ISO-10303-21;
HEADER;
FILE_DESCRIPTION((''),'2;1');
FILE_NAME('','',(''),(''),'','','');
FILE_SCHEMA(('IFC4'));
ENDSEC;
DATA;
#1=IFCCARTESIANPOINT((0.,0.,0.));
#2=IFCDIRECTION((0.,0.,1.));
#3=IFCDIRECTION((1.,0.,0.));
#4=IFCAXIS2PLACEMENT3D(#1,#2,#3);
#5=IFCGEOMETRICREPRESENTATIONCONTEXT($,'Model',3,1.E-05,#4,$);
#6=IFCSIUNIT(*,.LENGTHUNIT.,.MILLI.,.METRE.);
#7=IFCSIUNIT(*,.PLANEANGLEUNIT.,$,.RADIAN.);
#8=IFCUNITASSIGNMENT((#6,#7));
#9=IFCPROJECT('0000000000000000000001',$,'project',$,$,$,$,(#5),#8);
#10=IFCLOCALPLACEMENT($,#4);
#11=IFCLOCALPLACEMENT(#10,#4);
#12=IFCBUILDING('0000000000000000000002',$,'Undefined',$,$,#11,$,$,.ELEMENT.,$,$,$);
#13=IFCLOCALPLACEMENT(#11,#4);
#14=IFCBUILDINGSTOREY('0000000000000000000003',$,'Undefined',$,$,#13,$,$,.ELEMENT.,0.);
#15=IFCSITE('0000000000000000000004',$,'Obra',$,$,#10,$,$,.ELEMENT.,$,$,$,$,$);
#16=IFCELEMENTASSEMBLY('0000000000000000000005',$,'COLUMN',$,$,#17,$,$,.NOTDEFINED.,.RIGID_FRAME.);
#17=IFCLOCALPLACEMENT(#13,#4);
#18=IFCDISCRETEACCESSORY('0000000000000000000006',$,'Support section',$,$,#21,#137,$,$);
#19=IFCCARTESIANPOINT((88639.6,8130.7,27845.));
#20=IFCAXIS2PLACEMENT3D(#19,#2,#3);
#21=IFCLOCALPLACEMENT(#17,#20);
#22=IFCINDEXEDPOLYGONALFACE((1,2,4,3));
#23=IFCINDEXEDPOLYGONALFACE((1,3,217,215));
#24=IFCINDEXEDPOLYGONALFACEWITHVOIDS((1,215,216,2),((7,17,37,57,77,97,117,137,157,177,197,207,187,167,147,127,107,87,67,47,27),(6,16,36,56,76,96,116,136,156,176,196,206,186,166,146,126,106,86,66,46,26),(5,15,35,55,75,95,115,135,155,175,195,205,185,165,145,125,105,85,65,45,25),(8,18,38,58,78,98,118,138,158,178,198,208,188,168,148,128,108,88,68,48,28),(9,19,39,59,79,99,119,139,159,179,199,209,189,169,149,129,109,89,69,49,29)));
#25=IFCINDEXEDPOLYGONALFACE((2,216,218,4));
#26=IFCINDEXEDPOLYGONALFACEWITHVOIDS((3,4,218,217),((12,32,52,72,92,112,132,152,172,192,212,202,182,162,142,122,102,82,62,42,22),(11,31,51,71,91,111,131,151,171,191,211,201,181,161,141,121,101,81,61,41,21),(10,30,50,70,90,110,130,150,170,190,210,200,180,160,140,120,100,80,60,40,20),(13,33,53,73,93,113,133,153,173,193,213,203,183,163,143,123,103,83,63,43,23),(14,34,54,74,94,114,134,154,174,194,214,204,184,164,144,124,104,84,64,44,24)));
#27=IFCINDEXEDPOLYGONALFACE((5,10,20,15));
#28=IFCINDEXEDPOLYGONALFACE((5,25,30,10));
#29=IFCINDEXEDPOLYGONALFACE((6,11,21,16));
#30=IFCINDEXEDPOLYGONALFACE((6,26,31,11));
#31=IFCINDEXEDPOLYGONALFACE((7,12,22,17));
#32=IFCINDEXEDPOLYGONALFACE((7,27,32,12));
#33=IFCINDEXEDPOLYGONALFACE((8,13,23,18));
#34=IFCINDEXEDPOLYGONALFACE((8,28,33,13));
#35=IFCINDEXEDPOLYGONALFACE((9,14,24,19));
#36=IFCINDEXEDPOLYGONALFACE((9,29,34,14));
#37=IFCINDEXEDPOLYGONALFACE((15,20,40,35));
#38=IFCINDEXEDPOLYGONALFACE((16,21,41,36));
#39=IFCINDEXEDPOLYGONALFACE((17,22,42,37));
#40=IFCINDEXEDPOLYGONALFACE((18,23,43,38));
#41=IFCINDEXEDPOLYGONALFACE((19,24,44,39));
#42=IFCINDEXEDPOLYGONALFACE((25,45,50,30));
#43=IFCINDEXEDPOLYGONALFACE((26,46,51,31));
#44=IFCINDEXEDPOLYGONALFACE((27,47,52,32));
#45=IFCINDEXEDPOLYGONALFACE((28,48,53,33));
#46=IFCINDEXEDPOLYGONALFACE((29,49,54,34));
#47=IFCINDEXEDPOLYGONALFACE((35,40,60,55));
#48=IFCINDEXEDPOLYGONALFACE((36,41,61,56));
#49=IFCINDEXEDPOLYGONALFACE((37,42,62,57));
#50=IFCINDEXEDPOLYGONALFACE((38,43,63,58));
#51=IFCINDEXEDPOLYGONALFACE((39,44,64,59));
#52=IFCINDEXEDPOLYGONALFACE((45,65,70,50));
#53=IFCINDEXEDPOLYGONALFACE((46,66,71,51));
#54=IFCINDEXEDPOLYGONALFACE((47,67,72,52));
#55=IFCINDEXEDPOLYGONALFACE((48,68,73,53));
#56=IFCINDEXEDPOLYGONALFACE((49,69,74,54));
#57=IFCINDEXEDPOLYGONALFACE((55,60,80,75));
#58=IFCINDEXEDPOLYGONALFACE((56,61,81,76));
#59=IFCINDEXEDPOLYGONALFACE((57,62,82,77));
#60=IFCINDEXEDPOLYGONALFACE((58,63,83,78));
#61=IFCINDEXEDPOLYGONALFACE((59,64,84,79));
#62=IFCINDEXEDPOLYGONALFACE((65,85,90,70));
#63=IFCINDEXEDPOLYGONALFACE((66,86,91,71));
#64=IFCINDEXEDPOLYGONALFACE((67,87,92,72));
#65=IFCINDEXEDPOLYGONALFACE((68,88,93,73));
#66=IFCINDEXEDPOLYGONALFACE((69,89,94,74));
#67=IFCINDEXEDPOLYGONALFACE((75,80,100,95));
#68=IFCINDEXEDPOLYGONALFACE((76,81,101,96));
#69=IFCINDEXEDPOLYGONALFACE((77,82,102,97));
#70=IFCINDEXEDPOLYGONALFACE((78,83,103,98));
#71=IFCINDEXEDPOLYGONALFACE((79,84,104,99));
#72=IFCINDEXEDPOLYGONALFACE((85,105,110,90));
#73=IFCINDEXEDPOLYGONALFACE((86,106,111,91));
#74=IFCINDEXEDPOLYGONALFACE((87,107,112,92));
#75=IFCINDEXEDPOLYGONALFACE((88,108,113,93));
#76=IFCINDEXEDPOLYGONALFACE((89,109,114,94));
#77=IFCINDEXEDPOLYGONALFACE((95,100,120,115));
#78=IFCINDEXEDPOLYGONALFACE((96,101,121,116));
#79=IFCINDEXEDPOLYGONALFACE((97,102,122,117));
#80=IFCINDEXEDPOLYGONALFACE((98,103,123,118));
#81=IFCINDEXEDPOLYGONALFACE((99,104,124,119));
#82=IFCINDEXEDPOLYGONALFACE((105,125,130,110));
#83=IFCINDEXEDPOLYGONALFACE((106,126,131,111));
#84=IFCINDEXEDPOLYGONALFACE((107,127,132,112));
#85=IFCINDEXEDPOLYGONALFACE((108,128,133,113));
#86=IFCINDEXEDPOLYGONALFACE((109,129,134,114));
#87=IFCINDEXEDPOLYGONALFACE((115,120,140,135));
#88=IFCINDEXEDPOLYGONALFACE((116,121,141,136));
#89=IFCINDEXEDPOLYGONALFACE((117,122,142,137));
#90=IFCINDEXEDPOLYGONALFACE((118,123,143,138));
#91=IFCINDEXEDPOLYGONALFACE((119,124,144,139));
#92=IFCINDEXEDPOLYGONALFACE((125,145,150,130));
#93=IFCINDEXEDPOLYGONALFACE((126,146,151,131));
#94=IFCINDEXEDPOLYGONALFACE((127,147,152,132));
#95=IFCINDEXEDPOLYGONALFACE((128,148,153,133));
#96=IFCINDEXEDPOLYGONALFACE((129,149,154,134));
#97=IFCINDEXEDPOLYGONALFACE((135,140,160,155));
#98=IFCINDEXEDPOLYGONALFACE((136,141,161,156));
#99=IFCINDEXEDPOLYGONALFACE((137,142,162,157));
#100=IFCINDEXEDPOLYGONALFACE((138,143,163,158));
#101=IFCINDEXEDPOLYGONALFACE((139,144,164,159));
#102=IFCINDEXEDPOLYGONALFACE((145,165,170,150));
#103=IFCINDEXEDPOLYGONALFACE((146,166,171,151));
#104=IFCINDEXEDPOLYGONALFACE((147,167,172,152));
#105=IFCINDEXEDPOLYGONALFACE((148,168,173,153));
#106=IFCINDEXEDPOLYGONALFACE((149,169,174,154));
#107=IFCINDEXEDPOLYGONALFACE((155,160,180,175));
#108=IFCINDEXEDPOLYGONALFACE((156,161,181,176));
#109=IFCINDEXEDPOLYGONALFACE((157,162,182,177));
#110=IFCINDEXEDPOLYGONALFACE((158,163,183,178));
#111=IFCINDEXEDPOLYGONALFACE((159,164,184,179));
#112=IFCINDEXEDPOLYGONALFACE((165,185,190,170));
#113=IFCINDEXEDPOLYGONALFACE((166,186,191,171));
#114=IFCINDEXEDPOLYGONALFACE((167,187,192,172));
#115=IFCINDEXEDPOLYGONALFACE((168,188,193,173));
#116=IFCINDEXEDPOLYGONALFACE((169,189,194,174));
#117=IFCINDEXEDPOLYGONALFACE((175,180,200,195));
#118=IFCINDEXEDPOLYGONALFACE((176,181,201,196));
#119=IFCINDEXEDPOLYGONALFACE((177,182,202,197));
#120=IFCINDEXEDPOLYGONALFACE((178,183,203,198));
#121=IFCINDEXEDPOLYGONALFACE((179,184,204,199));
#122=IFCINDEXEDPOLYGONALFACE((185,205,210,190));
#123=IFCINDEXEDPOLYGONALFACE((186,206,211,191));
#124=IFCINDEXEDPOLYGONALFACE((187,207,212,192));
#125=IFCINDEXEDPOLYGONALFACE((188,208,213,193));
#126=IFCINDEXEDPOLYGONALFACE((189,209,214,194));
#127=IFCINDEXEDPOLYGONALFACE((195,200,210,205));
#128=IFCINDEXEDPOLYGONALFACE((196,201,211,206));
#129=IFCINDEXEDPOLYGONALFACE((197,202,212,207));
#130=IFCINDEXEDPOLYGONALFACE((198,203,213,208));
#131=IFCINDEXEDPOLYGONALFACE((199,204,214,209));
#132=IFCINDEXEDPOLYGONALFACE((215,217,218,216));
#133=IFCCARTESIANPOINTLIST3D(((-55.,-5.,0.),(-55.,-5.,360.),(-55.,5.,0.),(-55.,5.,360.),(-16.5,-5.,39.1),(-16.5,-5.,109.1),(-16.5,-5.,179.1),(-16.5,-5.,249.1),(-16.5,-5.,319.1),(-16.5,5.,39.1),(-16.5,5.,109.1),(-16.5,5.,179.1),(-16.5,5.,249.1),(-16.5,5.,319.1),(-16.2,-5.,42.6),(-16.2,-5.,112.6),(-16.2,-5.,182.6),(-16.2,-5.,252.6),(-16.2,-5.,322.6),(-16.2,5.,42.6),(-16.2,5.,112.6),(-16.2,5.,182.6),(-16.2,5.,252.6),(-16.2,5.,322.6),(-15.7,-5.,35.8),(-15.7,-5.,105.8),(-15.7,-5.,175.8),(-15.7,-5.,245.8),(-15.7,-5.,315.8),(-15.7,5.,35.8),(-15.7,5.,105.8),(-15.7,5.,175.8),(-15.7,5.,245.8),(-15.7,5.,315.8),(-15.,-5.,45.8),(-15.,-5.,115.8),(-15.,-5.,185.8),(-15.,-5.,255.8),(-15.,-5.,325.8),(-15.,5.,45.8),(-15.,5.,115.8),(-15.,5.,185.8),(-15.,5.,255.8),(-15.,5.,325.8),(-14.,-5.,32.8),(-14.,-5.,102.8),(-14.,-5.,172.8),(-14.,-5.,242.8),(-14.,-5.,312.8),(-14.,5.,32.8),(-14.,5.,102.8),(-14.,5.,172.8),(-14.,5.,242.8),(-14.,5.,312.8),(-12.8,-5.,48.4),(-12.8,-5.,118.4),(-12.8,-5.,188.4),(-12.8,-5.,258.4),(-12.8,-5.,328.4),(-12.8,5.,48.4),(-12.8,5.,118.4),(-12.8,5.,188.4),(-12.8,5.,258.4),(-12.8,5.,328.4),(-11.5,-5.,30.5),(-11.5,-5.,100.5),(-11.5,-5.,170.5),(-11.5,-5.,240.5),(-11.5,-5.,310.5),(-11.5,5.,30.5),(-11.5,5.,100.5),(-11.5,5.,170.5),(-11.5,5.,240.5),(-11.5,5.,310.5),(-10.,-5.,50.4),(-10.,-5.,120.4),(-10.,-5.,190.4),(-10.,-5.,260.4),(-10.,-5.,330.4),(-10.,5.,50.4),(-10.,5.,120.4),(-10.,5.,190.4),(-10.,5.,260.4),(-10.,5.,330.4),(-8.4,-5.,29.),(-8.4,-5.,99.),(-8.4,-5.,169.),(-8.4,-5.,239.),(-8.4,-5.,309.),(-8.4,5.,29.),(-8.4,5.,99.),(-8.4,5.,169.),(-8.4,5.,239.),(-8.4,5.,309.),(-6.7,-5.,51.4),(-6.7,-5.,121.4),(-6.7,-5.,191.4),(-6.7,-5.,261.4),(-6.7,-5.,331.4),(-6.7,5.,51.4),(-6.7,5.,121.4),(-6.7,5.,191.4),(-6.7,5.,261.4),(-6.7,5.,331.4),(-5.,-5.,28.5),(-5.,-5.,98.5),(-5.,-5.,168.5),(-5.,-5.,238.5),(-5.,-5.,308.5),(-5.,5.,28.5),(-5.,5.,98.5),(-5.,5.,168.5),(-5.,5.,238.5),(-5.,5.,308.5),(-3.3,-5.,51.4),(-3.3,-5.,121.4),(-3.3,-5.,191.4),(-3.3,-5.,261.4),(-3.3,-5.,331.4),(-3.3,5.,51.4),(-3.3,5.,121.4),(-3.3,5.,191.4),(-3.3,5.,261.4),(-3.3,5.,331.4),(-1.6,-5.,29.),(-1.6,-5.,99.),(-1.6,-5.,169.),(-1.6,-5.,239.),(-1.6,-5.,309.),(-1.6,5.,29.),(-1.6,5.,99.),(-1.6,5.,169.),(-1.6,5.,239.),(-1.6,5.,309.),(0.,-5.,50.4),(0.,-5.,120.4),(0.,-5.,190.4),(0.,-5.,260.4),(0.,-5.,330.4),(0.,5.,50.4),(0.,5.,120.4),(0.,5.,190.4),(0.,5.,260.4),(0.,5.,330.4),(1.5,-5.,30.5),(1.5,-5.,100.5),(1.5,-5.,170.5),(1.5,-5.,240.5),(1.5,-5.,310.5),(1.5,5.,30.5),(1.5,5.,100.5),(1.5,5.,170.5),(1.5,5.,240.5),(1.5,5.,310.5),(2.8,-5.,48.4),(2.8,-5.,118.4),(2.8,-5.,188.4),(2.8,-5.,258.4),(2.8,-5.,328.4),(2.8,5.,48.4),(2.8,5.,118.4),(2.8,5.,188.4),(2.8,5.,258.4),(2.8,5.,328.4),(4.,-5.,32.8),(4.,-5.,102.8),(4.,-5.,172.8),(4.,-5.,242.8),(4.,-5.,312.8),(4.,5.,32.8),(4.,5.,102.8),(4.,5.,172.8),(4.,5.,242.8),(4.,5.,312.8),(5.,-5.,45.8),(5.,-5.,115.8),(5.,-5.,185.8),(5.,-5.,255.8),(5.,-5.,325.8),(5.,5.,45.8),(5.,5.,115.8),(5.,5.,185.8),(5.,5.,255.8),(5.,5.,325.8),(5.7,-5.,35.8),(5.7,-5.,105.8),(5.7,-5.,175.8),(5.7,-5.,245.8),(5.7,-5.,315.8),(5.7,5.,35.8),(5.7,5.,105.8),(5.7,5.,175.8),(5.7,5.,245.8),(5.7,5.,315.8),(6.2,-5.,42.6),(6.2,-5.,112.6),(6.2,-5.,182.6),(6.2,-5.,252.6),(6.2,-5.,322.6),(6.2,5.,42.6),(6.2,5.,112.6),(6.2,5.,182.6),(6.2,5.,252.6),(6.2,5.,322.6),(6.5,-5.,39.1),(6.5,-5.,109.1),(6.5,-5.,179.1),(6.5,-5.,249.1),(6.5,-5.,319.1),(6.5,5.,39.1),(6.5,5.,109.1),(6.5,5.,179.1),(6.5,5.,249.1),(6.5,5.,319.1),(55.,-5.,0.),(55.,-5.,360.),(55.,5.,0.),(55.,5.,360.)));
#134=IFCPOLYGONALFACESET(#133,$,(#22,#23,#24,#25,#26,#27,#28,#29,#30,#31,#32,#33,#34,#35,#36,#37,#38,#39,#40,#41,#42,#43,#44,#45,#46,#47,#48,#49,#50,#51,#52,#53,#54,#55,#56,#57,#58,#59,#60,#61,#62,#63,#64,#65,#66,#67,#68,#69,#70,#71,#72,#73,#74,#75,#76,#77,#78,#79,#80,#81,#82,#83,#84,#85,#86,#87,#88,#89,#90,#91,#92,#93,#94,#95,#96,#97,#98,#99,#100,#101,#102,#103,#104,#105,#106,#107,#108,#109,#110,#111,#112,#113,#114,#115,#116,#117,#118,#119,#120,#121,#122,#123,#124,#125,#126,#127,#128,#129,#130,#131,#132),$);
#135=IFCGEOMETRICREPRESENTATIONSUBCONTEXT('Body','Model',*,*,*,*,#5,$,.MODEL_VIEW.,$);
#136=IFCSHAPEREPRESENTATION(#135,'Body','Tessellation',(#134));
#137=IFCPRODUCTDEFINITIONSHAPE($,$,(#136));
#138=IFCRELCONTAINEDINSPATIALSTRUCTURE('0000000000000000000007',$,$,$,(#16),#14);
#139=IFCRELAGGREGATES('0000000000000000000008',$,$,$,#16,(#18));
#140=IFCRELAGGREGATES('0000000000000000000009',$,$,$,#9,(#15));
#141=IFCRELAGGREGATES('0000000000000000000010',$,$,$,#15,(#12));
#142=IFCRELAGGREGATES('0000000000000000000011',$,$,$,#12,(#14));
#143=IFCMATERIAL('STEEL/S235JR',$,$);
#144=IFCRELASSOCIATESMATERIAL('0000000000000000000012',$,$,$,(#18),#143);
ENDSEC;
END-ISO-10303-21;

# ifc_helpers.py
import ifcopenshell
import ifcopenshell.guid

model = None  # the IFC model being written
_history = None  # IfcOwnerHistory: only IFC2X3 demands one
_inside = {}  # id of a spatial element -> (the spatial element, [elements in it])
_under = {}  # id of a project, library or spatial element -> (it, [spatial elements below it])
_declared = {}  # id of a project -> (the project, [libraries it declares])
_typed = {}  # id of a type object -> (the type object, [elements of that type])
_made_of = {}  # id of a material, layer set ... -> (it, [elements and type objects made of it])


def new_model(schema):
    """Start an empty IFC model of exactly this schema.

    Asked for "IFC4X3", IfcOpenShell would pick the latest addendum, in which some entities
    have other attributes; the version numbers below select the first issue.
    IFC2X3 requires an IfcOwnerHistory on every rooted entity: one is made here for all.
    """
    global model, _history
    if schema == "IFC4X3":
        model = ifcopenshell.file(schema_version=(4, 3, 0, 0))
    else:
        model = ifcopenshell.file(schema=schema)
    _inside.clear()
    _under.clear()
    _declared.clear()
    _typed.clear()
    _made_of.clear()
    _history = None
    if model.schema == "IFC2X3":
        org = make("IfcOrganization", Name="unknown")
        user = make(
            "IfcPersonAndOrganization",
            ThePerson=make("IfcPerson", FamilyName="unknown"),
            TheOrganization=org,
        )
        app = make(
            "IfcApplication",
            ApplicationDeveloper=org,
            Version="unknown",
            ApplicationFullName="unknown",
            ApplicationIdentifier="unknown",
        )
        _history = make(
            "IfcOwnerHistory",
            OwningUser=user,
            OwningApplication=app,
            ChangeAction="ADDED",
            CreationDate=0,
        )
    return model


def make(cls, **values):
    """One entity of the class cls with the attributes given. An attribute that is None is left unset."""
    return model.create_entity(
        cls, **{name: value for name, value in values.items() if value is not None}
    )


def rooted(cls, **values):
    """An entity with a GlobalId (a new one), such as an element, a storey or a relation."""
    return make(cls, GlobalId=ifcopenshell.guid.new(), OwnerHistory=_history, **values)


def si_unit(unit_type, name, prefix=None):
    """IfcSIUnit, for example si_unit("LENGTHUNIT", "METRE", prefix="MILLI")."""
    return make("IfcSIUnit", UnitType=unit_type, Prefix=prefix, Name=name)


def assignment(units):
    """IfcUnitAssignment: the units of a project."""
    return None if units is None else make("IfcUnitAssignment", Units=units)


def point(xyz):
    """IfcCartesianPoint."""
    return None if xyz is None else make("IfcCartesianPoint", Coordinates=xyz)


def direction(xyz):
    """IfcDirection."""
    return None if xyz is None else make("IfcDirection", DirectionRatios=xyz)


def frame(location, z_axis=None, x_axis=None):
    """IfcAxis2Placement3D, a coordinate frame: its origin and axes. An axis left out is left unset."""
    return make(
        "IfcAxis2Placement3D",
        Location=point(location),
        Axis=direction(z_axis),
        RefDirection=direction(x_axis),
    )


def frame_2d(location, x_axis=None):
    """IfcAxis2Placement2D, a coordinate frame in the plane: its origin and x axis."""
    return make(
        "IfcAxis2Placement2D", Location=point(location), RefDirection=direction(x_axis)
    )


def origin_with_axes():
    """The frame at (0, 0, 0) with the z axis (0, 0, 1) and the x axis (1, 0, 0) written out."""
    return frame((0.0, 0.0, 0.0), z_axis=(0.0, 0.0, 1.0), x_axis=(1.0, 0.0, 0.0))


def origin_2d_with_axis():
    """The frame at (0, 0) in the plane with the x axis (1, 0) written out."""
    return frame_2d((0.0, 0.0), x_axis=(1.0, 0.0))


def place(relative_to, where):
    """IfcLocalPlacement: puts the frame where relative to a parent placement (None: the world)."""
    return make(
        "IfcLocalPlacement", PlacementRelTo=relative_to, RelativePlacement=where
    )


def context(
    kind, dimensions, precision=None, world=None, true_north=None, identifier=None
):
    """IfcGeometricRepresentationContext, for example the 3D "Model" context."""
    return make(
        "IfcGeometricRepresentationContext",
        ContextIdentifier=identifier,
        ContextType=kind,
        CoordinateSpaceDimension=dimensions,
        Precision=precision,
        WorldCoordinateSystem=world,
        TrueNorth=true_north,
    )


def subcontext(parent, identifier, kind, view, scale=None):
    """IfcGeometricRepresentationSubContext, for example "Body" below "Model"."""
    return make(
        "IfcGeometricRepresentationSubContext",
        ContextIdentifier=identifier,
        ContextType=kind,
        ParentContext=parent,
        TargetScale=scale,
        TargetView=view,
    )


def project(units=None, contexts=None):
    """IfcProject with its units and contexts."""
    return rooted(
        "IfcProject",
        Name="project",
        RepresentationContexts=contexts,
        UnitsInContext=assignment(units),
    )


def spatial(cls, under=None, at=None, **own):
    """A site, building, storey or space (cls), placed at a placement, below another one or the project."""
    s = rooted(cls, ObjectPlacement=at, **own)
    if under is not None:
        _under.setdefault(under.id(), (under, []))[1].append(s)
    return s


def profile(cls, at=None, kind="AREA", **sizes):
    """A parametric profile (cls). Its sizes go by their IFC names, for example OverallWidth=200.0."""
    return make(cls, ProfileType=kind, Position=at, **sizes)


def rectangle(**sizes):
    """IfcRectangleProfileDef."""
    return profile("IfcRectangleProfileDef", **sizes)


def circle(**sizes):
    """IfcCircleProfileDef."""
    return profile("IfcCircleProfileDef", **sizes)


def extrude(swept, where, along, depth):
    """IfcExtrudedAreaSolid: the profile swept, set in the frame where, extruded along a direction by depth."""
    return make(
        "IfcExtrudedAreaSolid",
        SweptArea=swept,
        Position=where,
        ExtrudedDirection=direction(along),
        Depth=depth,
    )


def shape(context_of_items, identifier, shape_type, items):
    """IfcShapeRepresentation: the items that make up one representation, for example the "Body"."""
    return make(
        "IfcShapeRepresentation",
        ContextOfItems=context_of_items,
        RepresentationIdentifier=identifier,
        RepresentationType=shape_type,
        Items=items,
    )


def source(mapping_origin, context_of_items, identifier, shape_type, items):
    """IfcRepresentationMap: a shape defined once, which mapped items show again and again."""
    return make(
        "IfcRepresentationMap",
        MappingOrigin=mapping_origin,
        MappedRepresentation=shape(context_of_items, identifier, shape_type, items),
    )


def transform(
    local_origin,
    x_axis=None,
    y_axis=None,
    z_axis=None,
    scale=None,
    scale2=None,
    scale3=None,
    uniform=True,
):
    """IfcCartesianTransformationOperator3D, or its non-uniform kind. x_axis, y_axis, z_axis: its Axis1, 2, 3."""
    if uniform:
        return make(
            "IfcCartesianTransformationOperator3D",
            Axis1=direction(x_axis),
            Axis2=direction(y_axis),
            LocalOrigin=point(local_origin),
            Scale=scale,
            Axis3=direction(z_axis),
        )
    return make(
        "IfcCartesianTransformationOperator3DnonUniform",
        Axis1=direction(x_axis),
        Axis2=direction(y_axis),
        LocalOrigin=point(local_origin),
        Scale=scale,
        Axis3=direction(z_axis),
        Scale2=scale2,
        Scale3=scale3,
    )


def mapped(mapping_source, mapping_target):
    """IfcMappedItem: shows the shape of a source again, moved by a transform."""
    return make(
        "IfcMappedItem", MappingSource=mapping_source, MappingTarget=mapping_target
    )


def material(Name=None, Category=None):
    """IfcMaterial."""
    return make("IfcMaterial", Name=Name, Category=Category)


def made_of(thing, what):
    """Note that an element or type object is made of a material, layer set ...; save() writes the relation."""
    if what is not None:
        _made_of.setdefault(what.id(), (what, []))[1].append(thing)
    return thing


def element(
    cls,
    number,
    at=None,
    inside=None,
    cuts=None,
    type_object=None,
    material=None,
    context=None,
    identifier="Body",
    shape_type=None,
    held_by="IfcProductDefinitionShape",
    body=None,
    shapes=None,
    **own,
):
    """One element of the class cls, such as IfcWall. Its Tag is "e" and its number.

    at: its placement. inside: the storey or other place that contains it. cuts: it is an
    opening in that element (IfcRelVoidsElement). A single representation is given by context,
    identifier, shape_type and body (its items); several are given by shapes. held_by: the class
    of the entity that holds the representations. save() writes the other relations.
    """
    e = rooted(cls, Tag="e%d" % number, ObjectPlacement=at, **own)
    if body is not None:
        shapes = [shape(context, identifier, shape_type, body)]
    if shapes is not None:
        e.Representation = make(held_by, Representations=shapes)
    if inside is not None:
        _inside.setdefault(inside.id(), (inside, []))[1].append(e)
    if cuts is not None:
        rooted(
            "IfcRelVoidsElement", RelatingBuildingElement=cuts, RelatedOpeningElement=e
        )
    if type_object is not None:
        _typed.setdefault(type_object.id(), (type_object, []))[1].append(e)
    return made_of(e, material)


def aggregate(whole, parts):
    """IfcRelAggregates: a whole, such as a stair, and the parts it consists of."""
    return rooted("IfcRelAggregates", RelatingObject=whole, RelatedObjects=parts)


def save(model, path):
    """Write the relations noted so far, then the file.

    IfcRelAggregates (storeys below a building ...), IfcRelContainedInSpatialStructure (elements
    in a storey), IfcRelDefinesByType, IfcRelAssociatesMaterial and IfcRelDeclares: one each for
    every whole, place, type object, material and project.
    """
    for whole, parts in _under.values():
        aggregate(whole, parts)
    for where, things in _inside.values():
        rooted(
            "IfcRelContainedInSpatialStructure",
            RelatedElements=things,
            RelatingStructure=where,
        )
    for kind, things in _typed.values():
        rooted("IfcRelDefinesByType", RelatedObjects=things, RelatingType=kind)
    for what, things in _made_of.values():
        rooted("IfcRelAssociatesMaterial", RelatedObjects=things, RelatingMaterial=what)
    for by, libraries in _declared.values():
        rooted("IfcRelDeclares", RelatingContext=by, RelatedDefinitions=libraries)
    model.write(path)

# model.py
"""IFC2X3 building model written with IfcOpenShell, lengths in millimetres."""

from ifc_helpers import new_model, si_unit, frame, origin_with_axes, origin_2d_with_axis, place, context, subcontext, project, spatial, rectangle, circle, extrude, source, transform, mapped, material, element, aggregate, save


model = new_model("IFC2X3")

# Units and contexts
model_context = context("Model", 3, precision=1e-05, world=origin_with_axes())
body_context = subcontext(model_context, "Body", "Model", "MODEL_VIEW")
ifc_project = project(units=[si_unit("LENGTHUNIT", "METRE", prefix="MILLI"), si_unit("PLANEANGLEUNIT", "RADIAN")], contexts=[model_context])

# Site, building, storey
site_placement = place(None, origin_with_axes())
site = spatial("IfcSite", under=ifc_project, at=site_placement, Name="Obra", CompositionType="ELEMENT")
building_placement = place(site_placement, origin_with_axes())
building = spatial("IfcBuilding", under=site, at=building_placement, Name="Undefined", CompositionType="ELEMENT")
storey_placement = place(building_placement, origin_with_axes())
storey = spatial("IfcBuildingStorey", under=building, at=storey_placement, Name="Undefined", CompositionType="ELEMENT", Elevation=0.0)

# Element assembly
ifc_material = material(Name="STEEL/S235JR")
assembly_1_placement = place(storey_placement, origin_with_axes())
assembly_1 = element("IfcElementAssembly", 1, at=assembly_1_placement, inside=storey, Name="COLUMN", AssemblyPlace="NOTDEFINED", PredefinedType="RIGID_FRAME")

# Discrete accessory, opening
discrete_accessory_1_placement = place(assembly_1_placement, frame((88639.6, 8130.7, 27845.0), z_axis=(0.0, 0.0, 1.0), x_axis=(1.0, 0.0, 0.0)))
discrete_accessory_1 = element("IfcDiscreteAccessory", 2, at=discrete_accessory_1_placement, material=ifc_material, Name="Support section", context=body_context, shape_type="SweptSolid", body=[
    extrude(rectangle(XDim=10.0, YDim=110.0, at=origin_2d_with_axis()), frame((0.0, 0.0, 360.0), z_axis=(0.0, 0.0, -1.0), x_axis=(0.0, 1.0, 0.0)), (0.0, 0.0, 1.0), 360.0),
])
shared_shape_1 = source(origin_with_axes(), body_context, "Body", "SweptSolid", [
    extrude(circle(Radius=11.5, at=origin_2d_with_axis()), frame((0.0, -15.7, 0.0), z_axis=(0.0, 1.0, 0.0), x_axis=(1.0, 0.0, 0.0)), (0.0, 0.0, 1.0), 10.2),
])
opening_1_placement = place(assembly_1_placement, frame((88684.6, 8120.2, 28300.0), z_axis=(-1.0, 0.0, 0.0), x_axis=(0.0, 0.0, -1.0)))
element("IfcOpeningElement", 3, at=opening_1_placement, cuts=discrete_accessory_1, ObjectType="Opening", context=body_context, shape_type="MappedRepresentation", body=[
    mapped(shared_shape_1, transform((135.0, 0.0, 50.0))),
    mapped(shared_shape_1, transform((205.0, 0.0, 50.0))),
    mapped(shared_shape_1, transform((275.0, 0.0, 50.0))),
    mapped(shared_shape_1, transform((345.0, 0.0, 50.0))),
    mapped(shared_shape_1, transform((415.0, 0.0, 50.0))),
])
aggregate(assembly_1, [discrete_accessory_1])

save(model, "model.ifc")
